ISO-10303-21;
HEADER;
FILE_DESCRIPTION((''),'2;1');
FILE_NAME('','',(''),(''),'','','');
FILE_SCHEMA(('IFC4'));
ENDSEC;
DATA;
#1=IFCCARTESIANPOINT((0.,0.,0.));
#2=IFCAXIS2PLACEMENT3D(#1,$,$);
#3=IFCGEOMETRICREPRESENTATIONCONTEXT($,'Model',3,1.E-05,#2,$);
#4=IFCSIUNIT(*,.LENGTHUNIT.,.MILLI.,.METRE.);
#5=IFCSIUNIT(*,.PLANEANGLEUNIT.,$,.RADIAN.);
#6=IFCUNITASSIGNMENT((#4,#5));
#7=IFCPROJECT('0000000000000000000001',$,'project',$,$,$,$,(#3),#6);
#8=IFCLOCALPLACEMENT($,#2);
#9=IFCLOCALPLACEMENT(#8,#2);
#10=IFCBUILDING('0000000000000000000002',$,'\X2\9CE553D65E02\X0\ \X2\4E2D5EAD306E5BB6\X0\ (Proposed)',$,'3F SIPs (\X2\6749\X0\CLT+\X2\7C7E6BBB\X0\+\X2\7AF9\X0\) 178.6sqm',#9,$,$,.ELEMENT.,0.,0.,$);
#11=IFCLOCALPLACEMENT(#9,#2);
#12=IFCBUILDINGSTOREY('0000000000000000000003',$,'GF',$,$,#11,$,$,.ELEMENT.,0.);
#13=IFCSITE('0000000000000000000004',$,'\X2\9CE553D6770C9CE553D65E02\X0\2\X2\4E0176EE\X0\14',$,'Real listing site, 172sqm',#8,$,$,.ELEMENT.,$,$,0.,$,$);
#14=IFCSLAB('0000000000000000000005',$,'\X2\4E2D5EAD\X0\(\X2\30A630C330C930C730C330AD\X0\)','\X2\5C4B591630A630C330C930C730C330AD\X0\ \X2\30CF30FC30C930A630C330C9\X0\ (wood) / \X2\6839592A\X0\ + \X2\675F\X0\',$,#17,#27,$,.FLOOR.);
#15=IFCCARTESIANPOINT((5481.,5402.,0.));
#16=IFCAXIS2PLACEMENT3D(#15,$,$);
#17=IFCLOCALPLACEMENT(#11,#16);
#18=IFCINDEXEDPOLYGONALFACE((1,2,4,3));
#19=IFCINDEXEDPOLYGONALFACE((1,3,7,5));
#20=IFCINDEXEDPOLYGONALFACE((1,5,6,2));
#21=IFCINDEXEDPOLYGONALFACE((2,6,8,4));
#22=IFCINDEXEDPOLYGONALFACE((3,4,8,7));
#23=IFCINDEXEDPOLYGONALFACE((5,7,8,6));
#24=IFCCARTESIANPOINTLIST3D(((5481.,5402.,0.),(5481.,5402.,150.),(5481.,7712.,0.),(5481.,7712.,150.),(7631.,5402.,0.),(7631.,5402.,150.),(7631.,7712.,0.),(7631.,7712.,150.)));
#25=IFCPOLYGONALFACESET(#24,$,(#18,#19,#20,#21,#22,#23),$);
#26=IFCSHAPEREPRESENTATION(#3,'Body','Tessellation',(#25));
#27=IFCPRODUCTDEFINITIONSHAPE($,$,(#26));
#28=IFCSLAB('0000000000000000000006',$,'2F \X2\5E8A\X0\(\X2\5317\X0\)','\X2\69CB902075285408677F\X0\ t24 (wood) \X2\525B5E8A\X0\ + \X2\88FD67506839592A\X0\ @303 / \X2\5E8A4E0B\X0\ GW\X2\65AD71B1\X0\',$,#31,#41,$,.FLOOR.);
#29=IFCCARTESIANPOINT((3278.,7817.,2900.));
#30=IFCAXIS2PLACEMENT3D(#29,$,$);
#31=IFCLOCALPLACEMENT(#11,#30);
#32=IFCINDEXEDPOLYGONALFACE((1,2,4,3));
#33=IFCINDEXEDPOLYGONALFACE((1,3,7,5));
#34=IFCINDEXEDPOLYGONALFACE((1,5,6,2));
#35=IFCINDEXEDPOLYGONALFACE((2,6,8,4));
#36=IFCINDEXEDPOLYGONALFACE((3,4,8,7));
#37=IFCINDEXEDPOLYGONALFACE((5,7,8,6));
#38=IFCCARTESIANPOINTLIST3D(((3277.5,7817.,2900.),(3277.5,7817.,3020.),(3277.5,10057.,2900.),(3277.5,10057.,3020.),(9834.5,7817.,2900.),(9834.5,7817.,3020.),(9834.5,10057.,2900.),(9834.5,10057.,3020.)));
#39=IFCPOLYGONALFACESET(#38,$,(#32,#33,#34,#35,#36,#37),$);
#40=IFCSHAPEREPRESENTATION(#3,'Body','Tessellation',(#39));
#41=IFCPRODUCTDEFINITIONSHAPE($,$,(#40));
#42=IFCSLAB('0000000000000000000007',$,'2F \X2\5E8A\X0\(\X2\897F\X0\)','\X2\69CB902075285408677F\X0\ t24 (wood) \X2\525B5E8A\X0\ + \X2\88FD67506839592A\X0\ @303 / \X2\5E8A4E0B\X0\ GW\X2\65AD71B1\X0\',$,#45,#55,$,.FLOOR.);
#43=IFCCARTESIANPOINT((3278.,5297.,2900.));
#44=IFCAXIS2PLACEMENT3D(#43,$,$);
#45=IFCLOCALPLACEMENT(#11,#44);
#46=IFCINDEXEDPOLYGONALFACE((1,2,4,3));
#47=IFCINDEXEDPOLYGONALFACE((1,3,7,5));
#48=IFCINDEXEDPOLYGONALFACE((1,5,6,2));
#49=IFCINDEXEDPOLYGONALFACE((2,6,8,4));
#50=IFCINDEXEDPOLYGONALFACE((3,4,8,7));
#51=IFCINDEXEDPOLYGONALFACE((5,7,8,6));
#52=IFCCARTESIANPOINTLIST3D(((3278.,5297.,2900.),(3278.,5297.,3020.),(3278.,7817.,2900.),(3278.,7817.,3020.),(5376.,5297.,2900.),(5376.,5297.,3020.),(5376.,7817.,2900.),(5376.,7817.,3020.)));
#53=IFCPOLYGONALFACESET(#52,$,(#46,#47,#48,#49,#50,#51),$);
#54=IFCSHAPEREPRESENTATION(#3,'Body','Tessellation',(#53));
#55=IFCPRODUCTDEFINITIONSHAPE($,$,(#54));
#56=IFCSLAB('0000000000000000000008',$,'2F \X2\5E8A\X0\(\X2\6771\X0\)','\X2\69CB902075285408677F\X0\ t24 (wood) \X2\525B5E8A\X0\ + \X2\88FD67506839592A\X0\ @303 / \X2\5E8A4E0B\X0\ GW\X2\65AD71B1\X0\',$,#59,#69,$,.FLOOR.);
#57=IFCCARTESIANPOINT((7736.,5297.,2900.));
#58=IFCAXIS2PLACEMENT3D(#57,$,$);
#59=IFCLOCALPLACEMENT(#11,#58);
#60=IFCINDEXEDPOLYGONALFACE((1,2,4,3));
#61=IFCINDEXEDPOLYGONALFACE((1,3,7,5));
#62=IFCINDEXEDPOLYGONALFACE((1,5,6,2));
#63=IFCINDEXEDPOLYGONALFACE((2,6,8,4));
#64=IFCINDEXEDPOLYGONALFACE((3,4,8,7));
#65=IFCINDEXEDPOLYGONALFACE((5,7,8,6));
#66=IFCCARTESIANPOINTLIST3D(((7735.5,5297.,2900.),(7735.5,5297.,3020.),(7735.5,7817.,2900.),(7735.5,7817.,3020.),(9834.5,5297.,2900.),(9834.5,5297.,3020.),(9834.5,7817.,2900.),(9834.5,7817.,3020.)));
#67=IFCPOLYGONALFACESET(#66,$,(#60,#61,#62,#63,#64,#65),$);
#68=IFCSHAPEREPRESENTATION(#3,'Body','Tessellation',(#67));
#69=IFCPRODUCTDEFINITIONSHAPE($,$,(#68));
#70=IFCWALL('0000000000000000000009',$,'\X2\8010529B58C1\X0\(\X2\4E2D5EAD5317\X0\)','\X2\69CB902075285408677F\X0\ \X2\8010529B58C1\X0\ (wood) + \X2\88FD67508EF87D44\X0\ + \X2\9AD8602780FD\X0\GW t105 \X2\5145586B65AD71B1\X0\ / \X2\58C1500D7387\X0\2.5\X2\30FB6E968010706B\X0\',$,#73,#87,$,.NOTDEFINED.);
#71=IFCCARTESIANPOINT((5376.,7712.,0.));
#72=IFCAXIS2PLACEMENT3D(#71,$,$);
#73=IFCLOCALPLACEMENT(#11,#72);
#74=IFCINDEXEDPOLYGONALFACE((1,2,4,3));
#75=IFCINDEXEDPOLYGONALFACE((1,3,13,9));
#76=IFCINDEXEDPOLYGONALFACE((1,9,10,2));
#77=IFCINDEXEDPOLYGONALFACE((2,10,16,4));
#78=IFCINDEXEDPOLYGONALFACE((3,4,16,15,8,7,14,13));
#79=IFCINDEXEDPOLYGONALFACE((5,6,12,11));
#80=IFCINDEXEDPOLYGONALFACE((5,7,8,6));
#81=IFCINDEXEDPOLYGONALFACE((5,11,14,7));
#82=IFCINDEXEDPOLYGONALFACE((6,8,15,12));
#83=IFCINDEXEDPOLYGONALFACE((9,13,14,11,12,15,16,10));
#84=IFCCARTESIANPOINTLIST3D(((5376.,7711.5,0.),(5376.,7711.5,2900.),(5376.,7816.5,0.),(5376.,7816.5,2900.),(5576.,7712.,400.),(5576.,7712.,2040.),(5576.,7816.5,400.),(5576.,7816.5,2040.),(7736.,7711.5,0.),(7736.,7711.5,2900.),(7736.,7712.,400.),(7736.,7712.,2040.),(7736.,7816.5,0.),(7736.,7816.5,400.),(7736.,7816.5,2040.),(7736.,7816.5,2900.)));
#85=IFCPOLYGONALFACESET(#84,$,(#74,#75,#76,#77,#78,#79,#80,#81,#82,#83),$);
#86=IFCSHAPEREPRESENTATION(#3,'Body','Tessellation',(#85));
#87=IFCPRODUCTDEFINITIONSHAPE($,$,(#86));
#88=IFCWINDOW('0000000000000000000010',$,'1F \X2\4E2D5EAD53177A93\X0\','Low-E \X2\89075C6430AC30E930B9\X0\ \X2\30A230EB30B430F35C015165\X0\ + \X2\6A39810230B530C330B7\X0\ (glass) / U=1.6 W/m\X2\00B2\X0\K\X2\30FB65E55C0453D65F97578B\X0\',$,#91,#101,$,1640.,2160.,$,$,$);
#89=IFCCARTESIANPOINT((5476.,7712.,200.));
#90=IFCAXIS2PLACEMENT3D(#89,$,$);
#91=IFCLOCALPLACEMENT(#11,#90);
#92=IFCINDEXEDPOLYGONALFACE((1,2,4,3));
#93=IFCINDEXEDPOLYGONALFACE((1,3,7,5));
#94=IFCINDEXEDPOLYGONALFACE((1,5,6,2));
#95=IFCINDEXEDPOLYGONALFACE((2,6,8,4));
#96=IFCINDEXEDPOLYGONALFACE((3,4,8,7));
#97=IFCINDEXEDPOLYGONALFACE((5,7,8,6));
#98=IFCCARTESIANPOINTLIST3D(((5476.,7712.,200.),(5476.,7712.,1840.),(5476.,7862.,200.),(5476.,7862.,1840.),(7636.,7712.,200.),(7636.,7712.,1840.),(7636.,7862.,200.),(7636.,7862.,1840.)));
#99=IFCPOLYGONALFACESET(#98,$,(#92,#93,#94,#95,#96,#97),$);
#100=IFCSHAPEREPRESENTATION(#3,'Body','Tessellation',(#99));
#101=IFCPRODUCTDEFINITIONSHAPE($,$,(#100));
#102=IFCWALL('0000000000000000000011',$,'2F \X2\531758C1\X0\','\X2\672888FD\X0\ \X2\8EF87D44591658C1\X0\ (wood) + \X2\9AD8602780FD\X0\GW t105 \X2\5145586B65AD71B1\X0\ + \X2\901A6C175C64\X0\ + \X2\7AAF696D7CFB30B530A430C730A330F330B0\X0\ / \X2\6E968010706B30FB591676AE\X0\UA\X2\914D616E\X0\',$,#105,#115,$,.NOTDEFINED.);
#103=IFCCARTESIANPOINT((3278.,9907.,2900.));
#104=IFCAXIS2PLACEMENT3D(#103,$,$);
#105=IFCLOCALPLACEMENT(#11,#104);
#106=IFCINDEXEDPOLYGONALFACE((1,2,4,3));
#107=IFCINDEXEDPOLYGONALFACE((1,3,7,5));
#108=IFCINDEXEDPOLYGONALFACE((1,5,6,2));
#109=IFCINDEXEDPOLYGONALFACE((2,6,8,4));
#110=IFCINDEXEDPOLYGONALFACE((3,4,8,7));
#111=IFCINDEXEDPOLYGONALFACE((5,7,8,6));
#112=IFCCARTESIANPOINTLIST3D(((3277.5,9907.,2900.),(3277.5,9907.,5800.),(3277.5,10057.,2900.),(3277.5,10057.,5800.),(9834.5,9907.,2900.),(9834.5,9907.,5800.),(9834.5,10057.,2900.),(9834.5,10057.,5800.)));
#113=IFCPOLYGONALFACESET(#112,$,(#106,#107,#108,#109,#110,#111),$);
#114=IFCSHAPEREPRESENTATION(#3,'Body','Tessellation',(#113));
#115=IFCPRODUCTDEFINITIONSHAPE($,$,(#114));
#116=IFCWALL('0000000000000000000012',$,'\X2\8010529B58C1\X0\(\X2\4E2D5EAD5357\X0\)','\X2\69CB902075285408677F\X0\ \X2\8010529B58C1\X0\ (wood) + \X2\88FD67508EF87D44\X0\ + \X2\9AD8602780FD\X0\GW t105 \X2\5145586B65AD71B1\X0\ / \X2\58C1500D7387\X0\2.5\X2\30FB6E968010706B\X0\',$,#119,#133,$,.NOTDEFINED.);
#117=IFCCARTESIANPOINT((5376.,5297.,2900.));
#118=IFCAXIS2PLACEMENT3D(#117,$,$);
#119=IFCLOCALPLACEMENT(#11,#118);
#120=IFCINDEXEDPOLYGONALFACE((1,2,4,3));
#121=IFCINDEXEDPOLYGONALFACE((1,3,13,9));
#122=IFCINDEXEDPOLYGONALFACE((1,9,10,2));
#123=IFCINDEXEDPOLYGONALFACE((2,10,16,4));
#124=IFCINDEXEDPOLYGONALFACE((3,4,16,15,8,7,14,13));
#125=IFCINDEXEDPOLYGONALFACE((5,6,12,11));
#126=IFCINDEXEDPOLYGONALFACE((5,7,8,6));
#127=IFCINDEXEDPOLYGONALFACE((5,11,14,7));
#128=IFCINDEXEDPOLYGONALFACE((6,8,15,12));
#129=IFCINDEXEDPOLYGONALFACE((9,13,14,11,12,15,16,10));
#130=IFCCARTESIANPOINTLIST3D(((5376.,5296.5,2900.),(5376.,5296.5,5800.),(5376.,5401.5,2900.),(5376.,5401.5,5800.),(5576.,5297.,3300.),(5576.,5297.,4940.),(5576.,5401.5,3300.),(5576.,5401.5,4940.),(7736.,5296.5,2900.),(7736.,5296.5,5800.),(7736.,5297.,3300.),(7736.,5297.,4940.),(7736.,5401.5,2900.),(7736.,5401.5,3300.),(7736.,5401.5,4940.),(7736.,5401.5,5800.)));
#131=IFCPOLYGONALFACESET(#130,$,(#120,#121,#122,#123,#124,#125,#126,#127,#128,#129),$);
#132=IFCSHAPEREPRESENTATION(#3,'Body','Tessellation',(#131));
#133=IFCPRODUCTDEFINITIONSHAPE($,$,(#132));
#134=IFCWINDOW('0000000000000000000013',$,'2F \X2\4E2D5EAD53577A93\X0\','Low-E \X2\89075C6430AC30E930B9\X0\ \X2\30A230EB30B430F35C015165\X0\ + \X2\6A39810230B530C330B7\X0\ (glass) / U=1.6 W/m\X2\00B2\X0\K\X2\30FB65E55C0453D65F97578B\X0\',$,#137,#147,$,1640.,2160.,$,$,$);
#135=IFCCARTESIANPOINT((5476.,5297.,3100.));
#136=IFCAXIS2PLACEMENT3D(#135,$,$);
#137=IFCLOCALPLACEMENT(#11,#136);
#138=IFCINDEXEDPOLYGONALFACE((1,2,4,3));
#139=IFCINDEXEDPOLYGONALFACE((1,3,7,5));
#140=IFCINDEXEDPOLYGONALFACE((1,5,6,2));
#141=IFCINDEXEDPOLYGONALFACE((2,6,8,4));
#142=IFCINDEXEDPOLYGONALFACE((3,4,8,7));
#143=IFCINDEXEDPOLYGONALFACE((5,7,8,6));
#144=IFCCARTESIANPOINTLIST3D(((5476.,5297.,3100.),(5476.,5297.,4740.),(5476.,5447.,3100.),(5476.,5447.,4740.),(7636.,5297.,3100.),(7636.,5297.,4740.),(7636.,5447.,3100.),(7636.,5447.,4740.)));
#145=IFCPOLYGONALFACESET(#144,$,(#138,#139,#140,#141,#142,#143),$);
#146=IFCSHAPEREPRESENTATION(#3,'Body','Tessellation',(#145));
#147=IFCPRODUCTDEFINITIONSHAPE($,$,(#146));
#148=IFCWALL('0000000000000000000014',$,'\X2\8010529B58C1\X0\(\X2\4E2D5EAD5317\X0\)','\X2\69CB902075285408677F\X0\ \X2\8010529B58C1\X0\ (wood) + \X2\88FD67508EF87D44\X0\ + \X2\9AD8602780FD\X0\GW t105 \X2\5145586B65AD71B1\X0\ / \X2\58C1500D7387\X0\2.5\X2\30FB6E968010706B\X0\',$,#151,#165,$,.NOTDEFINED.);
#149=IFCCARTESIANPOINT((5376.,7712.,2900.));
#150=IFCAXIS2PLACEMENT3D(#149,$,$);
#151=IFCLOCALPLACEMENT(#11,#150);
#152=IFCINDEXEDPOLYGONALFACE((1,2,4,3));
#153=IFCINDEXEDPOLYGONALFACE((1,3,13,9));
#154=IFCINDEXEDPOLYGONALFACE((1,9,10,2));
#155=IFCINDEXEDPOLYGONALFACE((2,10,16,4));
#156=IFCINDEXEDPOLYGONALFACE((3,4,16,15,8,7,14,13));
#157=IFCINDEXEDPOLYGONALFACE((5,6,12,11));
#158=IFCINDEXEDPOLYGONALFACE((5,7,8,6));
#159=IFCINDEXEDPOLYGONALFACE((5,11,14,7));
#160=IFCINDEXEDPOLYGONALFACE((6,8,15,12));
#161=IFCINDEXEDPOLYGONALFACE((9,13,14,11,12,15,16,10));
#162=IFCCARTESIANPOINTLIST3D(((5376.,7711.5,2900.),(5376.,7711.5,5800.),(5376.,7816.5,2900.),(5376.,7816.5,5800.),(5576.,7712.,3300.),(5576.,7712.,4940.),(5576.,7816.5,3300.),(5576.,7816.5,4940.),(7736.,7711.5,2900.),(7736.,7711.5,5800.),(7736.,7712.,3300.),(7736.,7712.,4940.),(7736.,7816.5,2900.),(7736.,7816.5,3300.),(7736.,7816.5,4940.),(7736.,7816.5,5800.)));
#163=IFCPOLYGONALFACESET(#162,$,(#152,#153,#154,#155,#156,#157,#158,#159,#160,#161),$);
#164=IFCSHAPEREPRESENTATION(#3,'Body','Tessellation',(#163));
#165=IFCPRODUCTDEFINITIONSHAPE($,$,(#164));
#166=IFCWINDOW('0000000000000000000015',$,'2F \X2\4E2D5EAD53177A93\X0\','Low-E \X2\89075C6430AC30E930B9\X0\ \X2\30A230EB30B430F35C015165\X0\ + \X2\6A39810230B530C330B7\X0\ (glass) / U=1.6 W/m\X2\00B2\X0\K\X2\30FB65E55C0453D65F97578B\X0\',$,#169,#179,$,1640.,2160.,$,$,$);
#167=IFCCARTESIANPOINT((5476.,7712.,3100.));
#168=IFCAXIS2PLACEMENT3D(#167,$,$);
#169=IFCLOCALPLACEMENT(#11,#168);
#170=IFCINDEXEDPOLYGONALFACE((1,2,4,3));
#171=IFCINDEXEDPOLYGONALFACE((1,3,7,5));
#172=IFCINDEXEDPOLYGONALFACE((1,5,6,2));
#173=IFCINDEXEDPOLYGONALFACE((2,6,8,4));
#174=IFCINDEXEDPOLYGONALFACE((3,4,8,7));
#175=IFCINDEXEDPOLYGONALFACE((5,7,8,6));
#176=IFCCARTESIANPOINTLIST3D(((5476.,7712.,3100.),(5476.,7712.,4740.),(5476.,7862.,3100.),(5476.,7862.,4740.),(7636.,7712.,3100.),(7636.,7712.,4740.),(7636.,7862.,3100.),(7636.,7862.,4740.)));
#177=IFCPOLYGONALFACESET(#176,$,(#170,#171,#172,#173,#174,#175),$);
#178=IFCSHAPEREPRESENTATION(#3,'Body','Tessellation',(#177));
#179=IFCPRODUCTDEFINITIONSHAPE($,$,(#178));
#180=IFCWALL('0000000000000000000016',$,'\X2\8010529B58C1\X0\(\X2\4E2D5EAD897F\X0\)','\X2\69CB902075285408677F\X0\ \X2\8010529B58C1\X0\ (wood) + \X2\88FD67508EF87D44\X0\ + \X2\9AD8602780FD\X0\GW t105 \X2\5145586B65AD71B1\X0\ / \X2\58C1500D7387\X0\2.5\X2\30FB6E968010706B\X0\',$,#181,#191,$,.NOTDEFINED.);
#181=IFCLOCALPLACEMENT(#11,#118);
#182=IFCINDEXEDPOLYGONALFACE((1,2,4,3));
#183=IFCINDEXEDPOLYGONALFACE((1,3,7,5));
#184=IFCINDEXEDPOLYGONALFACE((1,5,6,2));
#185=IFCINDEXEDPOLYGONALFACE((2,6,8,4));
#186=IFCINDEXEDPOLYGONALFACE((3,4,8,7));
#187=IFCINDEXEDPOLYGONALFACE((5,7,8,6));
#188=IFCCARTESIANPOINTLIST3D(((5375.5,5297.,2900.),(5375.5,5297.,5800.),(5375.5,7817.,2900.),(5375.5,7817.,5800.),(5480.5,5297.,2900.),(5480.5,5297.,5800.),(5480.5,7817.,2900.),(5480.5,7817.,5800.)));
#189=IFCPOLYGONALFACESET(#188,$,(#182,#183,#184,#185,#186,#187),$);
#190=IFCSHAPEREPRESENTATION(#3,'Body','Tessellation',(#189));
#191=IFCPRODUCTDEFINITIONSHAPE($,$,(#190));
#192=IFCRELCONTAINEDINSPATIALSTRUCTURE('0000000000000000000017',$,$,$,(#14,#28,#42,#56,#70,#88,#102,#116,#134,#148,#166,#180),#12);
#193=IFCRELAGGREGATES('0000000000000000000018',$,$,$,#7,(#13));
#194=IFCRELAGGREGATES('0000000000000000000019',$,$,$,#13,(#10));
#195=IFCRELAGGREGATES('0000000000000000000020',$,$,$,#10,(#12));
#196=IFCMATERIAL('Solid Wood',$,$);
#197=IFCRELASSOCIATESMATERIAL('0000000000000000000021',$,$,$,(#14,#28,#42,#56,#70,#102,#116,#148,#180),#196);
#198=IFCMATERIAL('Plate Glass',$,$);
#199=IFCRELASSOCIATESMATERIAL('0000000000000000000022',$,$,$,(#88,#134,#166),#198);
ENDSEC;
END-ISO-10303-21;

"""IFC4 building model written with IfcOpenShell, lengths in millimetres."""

from ifc_helpers import new_model, si_unit, frame, frame_2d, origin, place, context, project, spatial, rectangle, extrude, material, element, fill, save


model = new_model("IFC4")

# Units and contexts
model_context = context("Model", 3, precision=1e-05, world=origin())
ifc_project = project(units=[si_unit("LENGTHUNIT", "METRE", prefix="MILLI"), si_unit("PLANEANGLEUNIT", "RADIAN")], contexts=[model_context])

# Site, building, storey
site_placement = place(None, origin())
site = spatial("IfcSite", under=ifc_project, at=site_placement, Name="鳥取県鳥取市2丁目14", ObjectType="Real listing site, 172sqm", CompositionType="ELEMENT", RefElevation=0.0)
building_placement = place(site_placement, origin())
building = spatial("IfcBuilding", under=site, at=building_placement, Name="鳥取市 中庭の家 (Proposed)", ObjectType="3F SIPs (杉CLT+籾殻+竹) 178.6sqm", CompositionType="ELEMENT", ElevationOfRefHeight=0.0, ElevationOfTerrain=0.0)
storey_placement = place(building_placement, origin())
storey = spatial("IfcBuildingStorey", under=building, at=storey_placement, Name="GF", CompositionType="ELEMENT", Elevation=0.0)

# Slabs
ifc_material_1 = material(Name="Solid Wood")
slab_1_placement = place(storey_placement, frame((5481.0, 5402.0, 0.0)))
element("IfcSlab", 1, at=slab_1_placement, inside=storey, material=ifc_material_1, Name="中庭(ウッドデッキ)", Description="屋外ウッドデッキ ハードウッド (wood) / 根太 + 束", PredefinedType="FLOOR", context=model_context, shape_type="SweptSolid", body=[
    extrude(rectangle(XDim=2150.0, YDim=2310.0, at=frame_2d((1075.0, 1155.0))), frame((5481.0, 5402.0, 0.0)), (0.0, 0.0, 1.0), 150.0),
])
slab_2_placement = place(storey_placement, frame((3278.0, 7817.0, 2900.0)))
element("IfcSlab", 2, at=slab_2_placement, inside=storey, material=ifc_material_1, Name="2F 床(北)", Description="構造用合板 t24 (wood) 剛床 + 製材根太 @303 / 床下 GW断熱", PredefinedType="FLOOR", context=model_context, shape_type="SweptSolid", body=[
    extrude(rectangle(XDim=6557.0, YDim=2240.0, at=frame_2d((3278.0, 1120.0))), frame((3278.0, 7817.0, 2900.0)), (0.0, 0.0, 1.0), 120.0),
])
slab_3_placement = place(storey_placement, frame((3278.0, 5297.0, 2900.0)))
element("IfcSlab", 3, at=slab_3_placement, inside=storey, material=ifc_material_1, Name="2F 床(西)", Description="構造用合板 t24 (wood) 剛床 + 製材根太 @303 / 床下 GW断熱", PredefinedType="FLOOR", context=model_context, shape_type="SweptSolid", body=[
    extrude(rectangle(XDim=2098.0, YDim=2520.0, at=frame_2d((1049.0, 1260.0))), frame((3278.0, 5297.0, 2900.0)), (0.0, 0.0, 1.0), 120.0),
])
slab_4_placement = place(storey_placement, frame((7736.0, 5297.0, 2900.0)))
element("IfcSlab", 4, at=slab_4_placement, inside=storey, material=ifc_material_1, Name="2F 床(東)", Description="構造用合板 t24 (wood) 剛床 + 製材根太 @303 / 床下 GW断熱", PredefinedType="FLOOR", context=model_context, shape_type="SweptSolid", body=[
    extrude(rectangle(XDim=2099.0, YDim=2520.0, at=frame_2d((1049.0, 1260.0))), frame((7736.0, 5297.0, 2900.0)), (0.0, 0.0, 1.0), 120.0),
])

# Wall, opening, window
wall_1_placement = place(storey_placement, frame((5376.0, 7712.0, 0.0)))
wall_1 = element("IfcWall", 5, at=wall_1_placement, inside=storey, material=ifc_material_1, Name="耐力壁(中庭北)", Description="構造用合板 耐力壁 (wood) + 製材軸組 + 高性能GW t105 充填断熱 / 壁倍率2.5・準耐火", PredefinedType="NOTDEFINED", context=model_context, shape_type="SweptSolid", body=[
    extrude(rectangle(XDim=2360.0, YDim=105.0, at=frame_2d((1180.0, 52.0))), frame((5376.0, 7712.0, 0.0)), (0.0, 0.0, 1.0), 2900.0),
])
opening_1_placement = place(storey_placement, frame((5476.0, 7712.0, 200.0)))
opening_1 = element("IfcOpeningElement", 6, at=opening_1_placement, cuts=wall_1, PredefinedType="NOTDEFINED", context=model_context, shape_type="SweptSolid", body=[
    extrude(rectangle(XDim=2160.0, YDim=150.0, at=frame_2d((1080.0, 75.0))), frame((5476.0, 7712.0, 200.0)), (0.0, 0.0, 1.0), 1640.0),
])
ifc_material_2 = material(Name="Plate Glass")
window_1_placement = place(storey_placement, frame((5476.0, 7712.0, 200.0)))
window_1 = element("IfcWindow", 7, at=window_1_placement, inside=storey, material=ifc_material_2, Name="1F 中庭北窓", Description="Low-E 複層ガラス アルゴン封入 + 樹脂サッシ (glass) / U=1.6 W/m²K・日射取得型", OverallHeight=1640.0, OverallWidth=2160.0, context=model_context, shape_type="SweptSolid", body=[
    extrude(rectangle(XDim=2160.0, YDim=150.0, at=frame_2d((1080.0, 75.0))), frame((5476.0, 7712.0, 200.0)), (0.0, 0.0, 1.0), 1640.0),
])
fill(opening_1, window_1)

# Wall
wall_2_placement = place(storey_placement, frame((3278.0, 9907.0, 2900.0)))
element("IfcWall", 8, at=wall_2_placement, inside=storey, material=ifc_material_1, Name="2F 北壁", Description="木製 軸組外壁 (wood) + 高性能GW t105 充填断熱 + 通気層 + 窯業系サイディング / 準耐火・外皮UA配慮", PredefinedType="NOTDEFINED", context=model_context, shape_type="SweptSolid", body=[
    extrude(rectangle(XDim=6557.0, YDim=150.0, at=frame_2d((3278.0, 75.0))), frame((3278.0, 9907.0, 2900.0)), (0.0, 0.0, 1.0), 2900.0),
])

# Walls, openings, windows
wall_3_placement = place(storey_placement, frame((5376.0, 5297.0, 2900.0)))
wall_3 = element("IfcWall", 9, at=wall_3_placement, inside=storey, material=ifc_material_1, Name="耐力壁(中庭南)", Description="構造用合板 耐力壁 (wood) + 製材軸組 + 高性能GW t105 充填断熱 / 壁倍率2.5・準耐火", PredefinedType="NOTDEFINED", context=model_context, shape_type="SweptSolid", body=[
    extrude(rectangle(XDim=2360.0, YDim=105.0, at=frame_2d((1180.0, 52.0))), frame((5376.0, 5297.0, 2900.0)), (0.0, 0.0, 1.0), 2900.0),
])
opening_2_placement = place(storey_placement, frame((5476.0, 5297.0, 3100.0)))
opening_2 = element("IfcOpeningElement", 10, at=opening_2_placement, cuts=wall_3, PredefinedType="NOTDEFINED", context=model_context, shape_type="SweptSolid", body=[
    extrude(rectangle(XDim=2160.0, YDim=150.0, at=frame_2d((1080.0, 75.0))), frame((5476.0, 5297.0, 3100.0)), (0.0, 0.0, 1.0), 1640.0),
])
window_2_placement = place(storey_placement, frame((5476.0, 5297.0, 3100.0)))
window_2 = element("IfcWindow", 11, at=window_2_placement, inside=storey, material=ifc_material_2, Name="2F 中庭南窓", Description="Low-E 複層ガラス アルゴン封入 + 樹脂サッシ (glass) / U=1.6 W/m²K・日射取得型", OverallHeight=1640.0, OverallWidth=2160.0, context=model_context, shape_type="SweptSolid", body=[
    extrude(rectangle(XDim=2160.0, YDim=150.0, at=frame_2d((1080.0, 75.0))), frame((5476.0, 5297.0, 3100.0)), (0.0, 0.0, 1.0), 1640.0),
])
fill(opening_2, window_2)
wall_4_placement = place(storey_placement, frame((5376.0, 7712.0, 2900.0)))
wall_4 = element("IfcWall", 12, at=wall_4_placement, inside=storey, material=ifc_material_1, Name="耐力壁(中庭北)", Description="構造用合板 耐力壁 (wood) + 製材軸組 + 高性能GW t105 充填断熱 / 壁倍率2.5・準耐火", PredefinedType="NOTDEFINED", context=model_context, shape_type="SweptSolid", body=[
    extrude(rectangle(XDim=2360.0, YDim=105.0, at=frame_2d((1180.0, 52.0))), frame((5376.0, 7712.0, 2900.0)), (0.0, 0.0, 1.0), 2900.0),
])
opening_3_placement = place(storey_placement, frame((5476.0, 7712.0, 3100.0)))
opening_3 = element("IfcOpeningElement", 13, at=opening_3_placement, cuts=wall_4, PredefinedType="NOTDEFINED", context=model_context, shape_type="SweptSolid", body=[
    extrude(rectangle(XDim=2160.0, YDim=150.0, at=frame_2d((1080.0, 75.0))), frame((5476.0, 7712.0, 3100.0)), (0.0, 0.0, 1.0), 1640.0),
])
window_3_placement = place(storey_placement, frame((5476.0, 7712.0, 3100.0)))
window_3 = element("IfcWindow", 14, at=window_3_placement, inside=storey, material=ifc_material_2, Name="2F 中庭北窓", Description="Low-E 複層ガラス アルゴン封入 + 樹脂サッシ (glass) / U=1.6 W/m²K・日射取得型", OverallHeight=1640.0, OverallWidth=2160.0, context=model_context, shape_type="SweptSolid", body=[
    extrude(rectangle(XDim=2160.0, YDim=150.0, at=frame_2d((1080.0, 75.0))), frame((5476.0, 7712.0, 3100.0)), (0.0, 0.0, 1.0), 1640.0),
])
fill(opening_3, window_3)

# Wall
wall_5_placement = place(storey_placement, frame((5376.0, 5297.0, 2900.0)))
element("IfcWall", 15, at=wall_5_placement, inside=storey, material=ifc_material_1, Name="耐力壁(中庭西)", Description="構造用合板 耐力壁 (wood) + 製材軸組 + 高性能GW t105 充填断熱 / 壁倍率2.5・準耐火", PredefinedType="NOTDEFINED", context=model_context, shape_type="SweptSolid", body=[
    extrude(rectangle(XDim=105.0, YDim=2520.0, at=frame_2d((52.0, 1260.0))), frame((5376.0, 5297.0, 2900.0)), (0.0, 0.0, 1.0), 2900.0),
])

save(model, "model.ifc")
